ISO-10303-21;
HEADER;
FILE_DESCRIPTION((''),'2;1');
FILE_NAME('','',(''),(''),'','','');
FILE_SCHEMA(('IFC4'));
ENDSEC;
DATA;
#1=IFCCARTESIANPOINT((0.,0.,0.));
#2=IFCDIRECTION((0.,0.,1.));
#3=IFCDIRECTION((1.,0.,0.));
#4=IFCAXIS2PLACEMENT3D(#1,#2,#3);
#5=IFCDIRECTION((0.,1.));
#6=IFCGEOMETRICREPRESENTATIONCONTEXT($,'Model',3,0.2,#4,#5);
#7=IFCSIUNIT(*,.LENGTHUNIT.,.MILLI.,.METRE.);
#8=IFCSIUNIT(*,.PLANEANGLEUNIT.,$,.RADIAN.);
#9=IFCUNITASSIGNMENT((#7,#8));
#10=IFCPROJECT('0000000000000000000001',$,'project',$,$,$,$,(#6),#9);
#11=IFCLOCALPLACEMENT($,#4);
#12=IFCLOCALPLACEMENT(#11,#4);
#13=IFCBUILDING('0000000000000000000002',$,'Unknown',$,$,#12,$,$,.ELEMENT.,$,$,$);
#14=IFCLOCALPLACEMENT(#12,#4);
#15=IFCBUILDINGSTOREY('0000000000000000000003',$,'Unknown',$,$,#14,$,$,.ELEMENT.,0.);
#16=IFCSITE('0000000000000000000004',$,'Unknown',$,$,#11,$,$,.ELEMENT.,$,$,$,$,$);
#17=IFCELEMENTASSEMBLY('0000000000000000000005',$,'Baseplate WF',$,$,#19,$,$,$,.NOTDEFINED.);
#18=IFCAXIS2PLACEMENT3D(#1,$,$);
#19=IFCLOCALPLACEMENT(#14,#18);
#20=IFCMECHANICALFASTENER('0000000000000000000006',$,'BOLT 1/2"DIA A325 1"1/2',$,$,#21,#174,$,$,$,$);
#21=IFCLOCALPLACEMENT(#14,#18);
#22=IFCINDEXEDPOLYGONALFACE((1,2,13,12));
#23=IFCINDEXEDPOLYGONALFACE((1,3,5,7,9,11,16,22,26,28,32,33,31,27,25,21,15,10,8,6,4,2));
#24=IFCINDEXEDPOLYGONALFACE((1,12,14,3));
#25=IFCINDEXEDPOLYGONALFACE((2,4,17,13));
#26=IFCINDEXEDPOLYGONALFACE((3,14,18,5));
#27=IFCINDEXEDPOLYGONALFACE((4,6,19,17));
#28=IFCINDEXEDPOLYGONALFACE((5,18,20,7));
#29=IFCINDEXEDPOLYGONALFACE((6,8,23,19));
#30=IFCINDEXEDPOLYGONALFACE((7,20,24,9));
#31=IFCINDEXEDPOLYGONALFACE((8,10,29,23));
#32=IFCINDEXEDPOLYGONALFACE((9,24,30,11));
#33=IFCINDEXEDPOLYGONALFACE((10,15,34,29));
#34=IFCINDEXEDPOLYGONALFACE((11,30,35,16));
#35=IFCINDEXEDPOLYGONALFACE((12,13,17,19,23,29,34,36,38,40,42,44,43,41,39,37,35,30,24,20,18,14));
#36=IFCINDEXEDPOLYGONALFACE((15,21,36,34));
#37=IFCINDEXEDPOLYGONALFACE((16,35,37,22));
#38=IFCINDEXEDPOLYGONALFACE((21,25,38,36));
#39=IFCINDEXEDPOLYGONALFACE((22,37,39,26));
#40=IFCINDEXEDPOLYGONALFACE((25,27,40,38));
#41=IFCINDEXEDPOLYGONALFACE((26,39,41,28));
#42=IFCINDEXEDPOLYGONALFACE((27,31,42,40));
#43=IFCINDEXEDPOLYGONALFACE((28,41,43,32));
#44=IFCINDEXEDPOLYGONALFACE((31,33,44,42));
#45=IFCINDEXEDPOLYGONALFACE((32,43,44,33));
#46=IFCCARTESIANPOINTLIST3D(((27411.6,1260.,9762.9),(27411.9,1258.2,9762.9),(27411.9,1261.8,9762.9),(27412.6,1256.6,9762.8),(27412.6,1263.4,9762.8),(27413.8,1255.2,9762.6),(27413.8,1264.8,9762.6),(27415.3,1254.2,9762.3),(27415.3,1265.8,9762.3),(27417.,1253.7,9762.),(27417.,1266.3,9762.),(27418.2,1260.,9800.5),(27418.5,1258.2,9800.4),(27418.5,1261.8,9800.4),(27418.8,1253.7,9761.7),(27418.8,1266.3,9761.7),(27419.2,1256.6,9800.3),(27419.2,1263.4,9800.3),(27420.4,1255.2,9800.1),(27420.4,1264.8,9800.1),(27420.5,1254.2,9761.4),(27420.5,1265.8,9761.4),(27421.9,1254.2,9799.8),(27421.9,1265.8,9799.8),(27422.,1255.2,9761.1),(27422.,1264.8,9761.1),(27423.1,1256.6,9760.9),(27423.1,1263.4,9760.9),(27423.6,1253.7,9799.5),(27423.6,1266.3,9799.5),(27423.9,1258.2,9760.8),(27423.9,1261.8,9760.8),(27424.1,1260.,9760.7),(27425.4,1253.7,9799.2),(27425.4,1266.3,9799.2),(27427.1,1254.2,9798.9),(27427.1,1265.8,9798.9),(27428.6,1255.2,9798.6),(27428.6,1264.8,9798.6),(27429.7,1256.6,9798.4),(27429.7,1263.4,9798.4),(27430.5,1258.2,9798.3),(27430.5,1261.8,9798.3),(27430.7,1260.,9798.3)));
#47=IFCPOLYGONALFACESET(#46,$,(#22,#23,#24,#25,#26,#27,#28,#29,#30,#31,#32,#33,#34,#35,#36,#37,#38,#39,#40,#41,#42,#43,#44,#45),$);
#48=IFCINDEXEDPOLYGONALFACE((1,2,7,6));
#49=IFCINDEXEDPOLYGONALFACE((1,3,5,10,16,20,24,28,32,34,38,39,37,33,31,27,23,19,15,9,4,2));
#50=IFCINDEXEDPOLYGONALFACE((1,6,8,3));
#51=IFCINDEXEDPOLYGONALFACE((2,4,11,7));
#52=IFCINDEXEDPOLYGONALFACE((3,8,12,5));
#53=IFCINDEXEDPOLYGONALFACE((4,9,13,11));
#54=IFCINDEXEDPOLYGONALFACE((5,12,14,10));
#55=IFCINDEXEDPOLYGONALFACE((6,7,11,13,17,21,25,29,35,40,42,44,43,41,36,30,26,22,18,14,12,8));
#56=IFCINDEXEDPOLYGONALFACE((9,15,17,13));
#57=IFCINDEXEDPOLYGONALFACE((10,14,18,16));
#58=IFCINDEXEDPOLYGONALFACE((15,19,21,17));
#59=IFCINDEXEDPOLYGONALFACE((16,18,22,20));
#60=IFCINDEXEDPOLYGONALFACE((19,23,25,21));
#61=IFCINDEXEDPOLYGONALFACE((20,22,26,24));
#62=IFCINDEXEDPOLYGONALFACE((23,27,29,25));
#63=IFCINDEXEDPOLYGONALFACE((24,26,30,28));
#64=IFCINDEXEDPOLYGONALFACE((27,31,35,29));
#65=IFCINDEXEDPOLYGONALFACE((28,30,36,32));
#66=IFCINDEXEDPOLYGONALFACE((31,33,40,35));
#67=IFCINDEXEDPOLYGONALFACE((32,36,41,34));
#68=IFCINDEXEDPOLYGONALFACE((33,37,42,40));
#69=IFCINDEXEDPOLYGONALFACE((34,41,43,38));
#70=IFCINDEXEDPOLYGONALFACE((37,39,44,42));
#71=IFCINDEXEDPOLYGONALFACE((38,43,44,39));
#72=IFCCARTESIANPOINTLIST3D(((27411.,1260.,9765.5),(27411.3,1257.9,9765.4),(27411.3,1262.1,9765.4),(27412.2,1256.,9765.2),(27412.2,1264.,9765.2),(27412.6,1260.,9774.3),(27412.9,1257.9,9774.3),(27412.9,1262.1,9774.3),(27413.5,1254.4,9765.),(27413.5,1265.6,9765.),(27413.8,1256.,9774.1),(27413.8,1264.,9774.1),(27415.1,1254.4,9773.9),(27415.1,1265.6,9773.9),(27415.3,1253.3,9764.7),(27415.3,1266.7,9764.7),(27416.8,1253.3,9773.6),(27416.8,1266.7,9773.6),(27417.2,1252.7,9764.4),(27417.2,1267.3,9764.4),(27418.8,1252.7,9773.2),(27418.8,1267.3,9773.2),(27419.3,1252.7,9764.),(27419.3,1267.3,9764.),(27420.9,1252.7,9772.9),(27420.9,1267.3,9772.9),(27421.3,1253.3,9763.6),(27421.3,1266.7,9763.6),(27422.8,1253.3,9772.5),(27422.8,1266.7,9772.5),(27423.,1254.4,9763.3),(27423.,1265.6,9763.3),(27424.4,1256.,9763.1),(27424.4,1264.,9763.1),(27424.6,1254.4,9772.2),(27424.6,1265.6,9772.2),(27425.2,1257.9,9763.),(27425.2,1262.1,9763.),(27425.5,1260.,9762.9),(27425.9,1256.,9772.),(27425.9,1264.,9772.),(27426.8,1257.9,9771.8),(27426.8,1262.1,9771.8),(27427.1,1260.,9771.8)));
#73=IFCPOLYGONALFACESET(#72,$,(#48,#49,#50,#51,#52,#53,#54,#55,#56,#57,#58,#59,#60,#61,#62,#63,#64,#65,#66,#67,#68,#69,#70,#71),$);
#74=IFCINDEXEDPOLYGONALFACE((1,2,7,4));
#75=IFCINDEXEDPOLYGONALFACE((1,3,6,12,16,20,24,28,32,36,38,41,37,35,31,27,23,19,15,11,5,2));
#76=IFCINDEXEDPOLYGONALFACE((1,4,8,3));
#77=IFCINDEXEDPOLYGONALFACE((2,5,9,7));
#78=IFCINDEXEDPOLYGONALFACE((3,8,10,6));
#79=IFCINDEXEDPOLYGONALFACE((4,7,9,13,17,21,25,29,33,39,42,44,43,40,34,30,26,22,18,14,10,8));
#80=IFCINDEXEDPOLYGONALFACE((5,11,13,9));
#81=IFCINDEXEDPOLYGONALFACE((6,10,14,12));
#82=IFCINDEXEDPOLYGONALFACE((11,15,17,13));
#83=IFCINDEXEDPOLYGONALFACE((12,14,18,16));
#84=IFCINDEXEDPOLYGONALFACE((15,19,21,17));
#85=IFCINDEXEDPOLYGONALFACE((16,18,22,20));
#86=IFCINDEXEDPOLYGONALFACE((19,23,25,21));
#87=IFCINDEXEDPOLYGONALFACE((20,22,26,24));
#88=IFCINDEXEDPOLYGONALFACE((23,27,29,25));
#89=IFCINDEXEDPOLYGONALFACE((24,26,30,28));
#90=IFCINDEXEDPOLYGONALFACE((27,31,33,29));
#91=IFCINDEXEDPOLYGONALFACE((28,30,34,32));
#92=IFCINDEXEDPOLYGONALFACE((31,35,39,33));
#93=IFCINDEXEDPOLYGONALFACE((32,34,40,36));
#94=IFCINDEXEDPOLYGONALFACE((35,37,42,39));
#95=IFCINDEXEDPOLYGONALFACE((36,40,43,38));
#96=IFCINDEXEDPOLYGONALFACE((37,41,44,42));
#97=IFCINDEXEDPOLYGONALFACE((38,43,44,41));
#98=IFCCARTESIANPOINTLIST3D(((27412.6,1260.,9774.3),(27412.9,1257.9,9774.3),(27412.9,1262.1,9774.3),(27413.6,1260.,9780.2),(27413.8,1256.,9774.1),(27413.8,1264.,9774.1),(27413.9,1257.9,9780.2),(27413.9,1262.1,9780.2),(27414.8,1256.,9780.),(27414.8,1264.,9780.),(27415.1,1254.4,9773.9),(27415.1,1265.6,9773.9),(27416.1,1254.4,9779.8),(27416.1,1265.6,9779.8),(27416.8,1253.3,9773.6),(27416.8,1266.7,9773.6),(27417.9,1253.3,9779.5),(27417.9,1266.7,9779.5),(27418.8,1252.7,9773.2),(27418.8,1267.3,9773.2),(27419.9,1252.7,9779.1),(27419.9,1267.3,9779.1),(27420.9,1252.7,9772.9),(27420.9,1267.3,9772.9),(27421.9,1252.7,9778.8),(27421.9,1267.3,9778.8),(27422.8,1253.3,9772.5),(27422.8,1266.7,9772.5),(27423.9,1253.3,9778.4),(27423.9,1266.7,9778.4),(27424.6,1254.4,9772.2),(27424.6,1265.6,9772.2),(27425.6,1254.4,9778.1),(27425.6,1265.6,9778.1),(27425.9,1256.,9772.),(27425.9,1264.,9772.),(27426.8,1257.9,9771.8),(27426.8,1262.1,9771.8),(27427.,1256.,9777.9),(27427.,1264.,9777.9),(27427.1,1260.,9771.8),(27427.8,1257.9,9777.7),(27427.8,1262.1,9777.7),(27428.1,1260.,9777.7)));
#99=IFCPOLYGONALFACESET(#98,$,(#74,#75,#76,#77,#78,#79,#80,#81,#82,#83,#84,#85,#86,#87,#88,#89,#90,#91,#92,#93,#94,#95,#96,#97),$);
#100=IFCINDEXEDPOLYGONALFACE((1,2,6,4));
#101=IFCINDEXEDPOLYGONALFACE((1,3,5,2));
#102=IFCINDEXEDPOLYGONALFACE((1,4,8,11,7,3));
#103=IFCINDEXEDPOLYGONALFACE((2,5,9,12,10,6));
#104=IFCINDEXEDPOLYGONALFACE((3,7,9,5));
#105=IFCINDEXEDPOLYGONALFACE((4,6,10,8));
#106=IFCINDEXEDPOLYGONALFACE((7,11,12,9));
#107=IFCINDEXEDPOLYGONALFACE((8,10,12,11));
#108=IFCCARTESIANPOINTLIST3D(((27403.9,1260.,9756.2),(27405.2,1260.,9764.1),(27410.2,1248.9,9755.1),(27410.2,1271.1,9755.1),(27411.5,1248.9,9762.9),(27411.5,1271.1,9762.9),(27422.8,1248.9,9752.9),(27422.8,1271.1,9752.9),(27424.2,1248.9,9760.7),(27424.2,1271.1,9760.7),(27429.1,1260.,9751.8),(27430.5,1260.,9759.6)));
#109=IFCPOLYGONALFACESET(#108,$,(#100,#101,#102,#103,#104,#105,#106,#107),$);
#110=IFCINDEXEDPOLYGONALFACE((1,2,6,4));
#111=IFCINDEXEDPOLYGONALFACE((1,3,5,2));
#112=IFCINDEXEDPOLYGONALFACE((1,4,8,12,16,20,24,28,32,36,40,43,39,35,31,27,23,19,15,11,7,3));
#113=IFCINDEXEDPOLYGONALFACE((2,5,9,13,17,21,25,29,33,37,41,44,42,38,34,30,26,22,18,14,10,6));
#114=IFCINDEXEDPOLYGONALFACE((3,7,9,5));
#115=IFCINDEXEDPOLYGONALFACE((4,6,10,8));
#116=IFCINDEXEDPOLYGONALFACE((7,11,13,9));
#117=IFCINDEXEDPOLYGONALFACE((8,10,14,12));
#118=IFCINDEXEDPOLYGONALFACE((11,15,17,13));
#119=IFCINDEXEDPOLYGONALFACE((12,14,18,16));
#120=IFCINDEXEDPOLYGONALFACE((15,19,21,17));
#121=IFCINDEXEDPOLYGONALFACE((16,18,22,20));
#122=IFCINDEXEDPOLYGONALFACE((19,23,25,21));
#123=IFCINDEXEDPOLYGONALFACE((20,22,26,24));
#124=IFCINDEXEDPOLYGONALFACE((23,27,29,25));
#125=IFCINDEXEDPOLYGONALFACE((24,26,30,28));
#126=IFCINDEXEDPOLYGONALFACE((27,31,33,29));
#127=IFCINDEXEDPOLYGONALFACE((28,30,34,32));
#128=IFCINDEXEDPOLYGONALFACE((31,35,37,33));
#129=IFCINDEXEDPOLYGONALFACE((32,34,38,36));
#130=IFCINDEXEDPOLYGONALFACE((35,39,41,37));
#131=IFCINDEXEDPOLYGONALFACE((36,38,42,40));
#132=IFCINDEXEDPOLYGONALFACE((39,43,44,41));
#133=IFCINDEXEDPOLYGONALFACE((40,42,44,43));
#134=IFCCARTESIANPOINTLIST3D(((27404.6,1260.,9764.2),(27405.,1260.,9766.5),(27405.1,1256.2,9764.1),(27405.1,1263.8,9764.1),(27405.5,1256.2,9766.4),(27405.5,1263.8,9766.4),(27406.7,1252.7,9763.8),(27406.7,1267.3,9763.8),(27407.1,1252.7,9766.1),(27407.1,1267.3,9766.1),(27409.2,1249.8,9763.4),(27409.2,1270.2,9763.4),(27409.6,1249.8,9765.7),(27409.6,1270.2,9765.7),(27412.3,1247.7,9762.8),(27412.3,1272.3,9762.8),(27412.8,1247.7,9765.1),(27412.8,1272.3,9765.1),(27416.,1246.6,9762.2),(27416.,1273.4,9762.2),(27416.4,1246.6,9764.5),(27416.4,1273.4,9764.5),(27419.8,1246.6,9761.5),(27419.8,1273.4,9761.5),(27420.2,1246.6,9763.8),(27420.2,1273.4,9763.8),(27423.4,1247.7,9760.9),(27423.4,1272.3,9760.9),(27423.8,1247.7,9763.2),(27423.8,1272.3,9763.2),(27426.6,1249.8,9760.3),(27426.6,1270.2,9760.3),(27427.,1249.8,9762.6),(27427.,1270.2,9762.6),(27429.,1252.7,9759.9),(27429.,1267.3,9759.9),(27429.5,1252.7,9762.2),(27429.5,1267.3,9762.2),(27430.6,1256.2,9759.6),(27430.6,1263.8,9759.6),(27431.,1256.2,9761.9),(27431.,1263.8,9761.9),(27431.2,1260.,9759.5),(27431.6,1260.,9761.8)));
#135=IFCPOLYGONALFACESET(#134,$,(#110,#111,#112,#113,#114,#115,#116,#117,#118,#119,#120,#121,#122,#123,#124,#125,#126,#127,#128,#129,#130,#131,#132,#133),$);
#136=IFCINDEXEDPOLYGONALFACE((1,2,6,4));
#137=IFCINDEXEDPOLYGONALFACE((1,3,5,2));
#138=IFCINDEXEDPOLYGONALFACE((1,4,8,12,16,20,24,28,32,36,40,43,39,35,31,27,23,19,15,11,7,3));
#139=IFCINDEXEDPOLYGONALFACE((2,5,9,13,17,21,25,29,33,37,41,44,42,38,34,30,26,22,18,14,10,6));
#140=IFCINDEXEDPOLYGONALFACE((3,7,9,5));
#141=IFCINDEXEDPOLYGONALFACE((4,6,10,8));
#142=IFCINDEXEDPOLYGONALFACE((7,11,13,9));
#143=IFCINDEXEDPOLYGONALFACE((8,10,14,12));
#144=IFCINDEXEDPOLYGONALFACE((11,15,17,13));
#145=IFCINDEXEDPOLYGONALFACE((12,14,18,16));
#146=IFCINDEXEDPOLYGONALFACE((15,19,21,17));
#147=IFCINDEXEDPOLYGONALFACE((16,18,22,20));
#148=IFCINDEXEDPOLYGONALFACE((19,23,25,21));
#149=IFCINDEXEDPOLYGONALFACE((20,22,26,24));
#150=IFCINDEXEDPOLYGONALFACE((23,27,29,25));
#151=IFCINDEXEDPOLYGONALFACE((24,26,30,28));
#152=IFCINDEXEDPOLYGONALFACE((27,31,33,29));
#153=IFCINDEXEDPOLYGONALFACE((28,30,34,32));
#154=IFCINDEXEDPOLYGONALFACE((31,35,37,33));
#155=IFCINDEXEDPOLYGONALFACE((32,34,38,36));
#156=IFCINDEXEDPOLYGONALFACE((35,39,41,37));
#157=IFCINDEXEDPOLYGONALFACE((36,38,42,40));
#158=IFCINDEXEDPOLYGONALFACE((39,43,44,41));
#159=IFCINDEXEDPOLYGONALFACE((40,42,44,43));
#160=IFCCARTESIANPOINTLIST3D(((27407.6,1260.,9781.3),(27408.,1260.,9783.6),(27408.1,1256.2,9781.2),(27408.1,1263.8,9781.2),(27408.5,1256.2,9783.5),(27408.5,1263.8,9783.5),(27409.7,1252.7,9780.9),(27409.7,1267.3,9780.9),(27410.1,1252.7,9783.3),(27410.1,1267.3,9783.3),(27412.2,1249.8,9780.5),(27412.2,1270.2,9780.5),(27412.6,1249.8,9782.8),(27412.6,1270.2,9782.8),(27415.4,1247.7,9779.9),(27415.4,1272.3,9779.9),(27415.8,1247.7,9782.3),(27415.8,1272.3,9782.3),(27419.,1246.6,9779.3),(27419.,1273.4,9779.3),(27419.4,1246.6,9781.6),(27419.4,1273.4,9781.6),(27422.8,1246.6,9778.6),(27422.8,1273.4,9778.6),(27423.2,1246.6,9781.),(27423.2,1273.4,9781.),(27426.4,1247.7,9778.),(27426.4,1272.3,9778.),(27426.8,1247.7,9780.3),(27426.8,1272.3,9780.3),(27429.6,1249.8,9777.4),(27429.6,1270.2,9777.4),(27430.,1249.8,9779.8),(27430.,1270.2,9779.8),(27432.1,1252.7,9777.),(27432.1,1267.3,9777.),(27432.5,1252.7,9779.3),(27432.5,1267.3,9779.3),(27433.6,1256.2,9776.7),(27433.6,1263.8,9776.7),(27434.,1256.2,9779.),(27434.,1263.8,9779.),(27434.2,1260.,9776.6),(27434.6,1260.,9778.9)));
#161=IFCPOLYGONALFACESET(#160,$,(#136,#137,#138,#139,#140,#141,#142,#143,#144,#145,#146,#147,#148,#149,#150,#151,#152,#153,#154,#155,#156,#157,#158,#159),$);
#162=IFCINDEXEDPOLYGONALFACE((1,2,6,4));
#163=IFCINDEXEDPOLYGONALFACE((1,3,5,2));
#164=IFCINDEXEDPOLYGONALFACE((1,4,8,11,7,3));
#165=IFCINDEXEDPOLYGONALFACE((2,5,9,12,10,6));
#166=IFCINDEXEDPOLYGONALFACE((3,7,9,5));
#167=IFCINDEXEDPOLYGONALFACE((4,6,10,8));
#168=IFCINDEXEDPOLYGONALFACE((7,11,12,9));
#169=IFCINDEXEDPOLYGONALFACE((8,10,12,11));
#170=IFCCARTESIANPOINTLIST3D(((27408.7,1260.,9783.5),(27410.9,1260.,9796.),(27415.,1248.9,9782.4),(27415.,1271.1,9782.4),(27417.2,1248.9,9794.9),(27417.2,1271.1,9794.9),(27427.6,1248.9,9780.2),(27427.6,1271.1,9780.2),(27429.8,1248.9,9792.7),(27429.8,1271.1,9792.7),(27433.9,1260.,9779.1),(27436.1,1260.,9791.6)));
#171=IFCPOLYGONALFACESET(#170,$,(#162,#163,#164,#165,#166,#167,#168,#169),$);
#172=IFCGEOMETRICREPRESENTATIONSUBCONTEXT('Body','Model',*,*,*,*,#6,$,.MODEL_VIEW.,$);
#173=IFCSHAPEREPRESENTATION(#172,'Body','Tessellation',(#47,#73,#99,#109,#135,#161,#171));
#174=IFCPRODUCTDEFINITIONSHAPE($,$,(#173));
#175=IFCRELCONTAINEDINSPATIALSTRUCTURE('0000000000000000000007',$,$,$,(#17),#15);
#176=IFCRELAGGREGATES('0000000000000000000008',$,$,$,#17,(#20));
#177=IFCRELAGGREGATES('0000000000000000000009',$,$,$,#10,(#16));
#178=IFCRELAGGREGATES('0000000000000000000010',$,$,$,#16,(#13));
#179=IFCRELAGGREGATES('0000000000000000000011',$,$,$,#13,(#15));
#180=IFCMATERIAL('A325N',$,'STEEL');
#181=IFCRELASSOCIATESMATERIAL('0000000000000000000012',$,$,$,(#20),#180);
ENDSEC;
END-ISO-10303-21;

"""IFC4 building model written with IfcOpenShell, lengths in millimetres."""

from ifc_helpers import new_model, si_unit, direction, frame, origin_with_axes, place, context, subcontext, project, spatial, line, arc, indexed_curve, outline, extrude, source, transform, mapped, material, element, aggregate, save


model = new_model("IFC4")

# Units and contexts
model_context = context("Model", 3, precision=0.2, world=origin_with_axes(), true_north=direction((0.0, 1.0)))
body_context = subcontext(model_context, "Body", "Model", "MODEL_VIEW")
ifc_project = project(units=[si_unit("LENGTHUNIT", "METRE", prefix="MILLI"), si_unit("PLANEANGLEUNIT", "RADIAN")], contexts=[model_context])

# Site, building, storey
site_placement = place(None, origin_with_axes())
site = spatial("IfcSite", under=ifc_project, at=site_placement, Name="Unknown", CompositionType="ELEMENT")
building_placement = place(site_placement, origin_with_axes())
building = spatial("IfcBuilding", under=site, at=building_placement, Name="Unknown", CompositionType="ELEMENT")
storey_placement = place(building_placement, origin_with_axes())
storey = spatial("IfcBuildingStorey", under=building, at=storey_placement, Name="Unknown", CompositionType="ELEMENT", Elevation=0.0)

# Element assembly
assembly_1_placement = place(storey_placement, frame((27449.9, 1290.0, 9770.8), z_axis=(-0.173648, 0.0, -0.984808), x_axis=(0.0, -1.0, 0.0)))
assembly_1 = element("IfcElementAssembly", 1, at=assembly_1_placement, inside=storey, Name="Baseplate WF", PredefinedType="NOTDEFINED")

# Mechanical fastener
ifc_material_1 = material(Name="A325N", Category="STEEL")
shared_shape = source(origin_with_axes(), body_context, "Body", "SweptSolid", [
    extrude(outline(indexed_curve([(6.3, 0.0), (0.0, 6.3), (-6.3, 0.0), (0.0, -6.3)], segments=[arc(1, 2, 3), arc(3, 4, 1)])), frame((0.0, 0.0, 17.4), z_axis=(0.0, 0.0, -1.0), x_axis=(0.0, 1.0, 0.0)), (0.0, 0.0, 1.0), 38.1),
    extrude(outline(indexed_curve([(7.3, 0.0), (0.0, 7.3), (-7.3, 0.0), (0.0, -7.3)], segments=[arc(1, 2, 3), arc(3, 4, 1)])), frame((0.0, 0.0, 15.0), z_axis=(0.0, 0.0, -1.0), x_axis=(0.0, 1.0, 0.0)), (0.0, 0.0, 1.0), 9.0),
    extrude(outline(indexed_curve([(7.3, 0.0), (0.0, 7.3), (-7.3, 0.0), (0.0, -7.3)], segments=[arc(1, 2, 3), arc(3, 4, 1)])), frame((0.0, 0.0, 6.0), z_axis=(0.0, 0.0, -1.0), x_axis=(0.0, 1.0, 0.0)), (0.0, 0.0, 1.0), 6.0),
    extrude(outline(indexed_curve([(12.8, 0.0), (6.4, 11.1), (-6.4, 11.1), (-12.8, 0.0), (-6.4, -11.1), (6.4, -11.1)], segments=[line(1, 2, 3, 4, 5, 6, 1)])), frame((0.0, 0.0, 25.3), z_axis=(0.0, 0.0, -1.0), x_axis=(0.0, 1.0, 0.0)), (0.0, 0.0, 1.0), 7.9),
    extrude(outline(indexed_curve([(13.5, 0.0), (0.0, 13.5), (-13.5, 0.0), (0.0, -13.5)], segments=[arc(1, 2, 3), arc(3, 4, 1)])), frame((0.0, 0.0, 17.4), z_axis=(0.0, 0.0, -1.0), x_axis=(0.0, 1.0, 0.0)), (0.0, 0.0, 1.0), 2.4),
    extrude(outline(indexed_curve([(13.5, 0.0), (0.0, 13.5), (-13.5, 0.0), (0.0, -13.5)], segments=[arc(1, 2, 3), arc(3, 4, 1)])), frame((0.0, 0.0, 0.0), z_axis=(0.0, 0.0, -1.0), x_axis=(0.0, 1.0, 0.0)), (0.0, 0.0, 1.0), 2.4),
    extrude(outline(indexed_curve([(12.8, 0.0), (6.4, 11.1), (-6.4, 11.1), (-12.8, 0.0), (-6.4, -11.1), (6.4, -11.1)], segments=[line(1, 2, 3, 4, 5, 6, 1)])), frame((0.0, 0.0, -2.4), z_axis=(0.0, 0.0, -1.0), x_axis=(0.0, 1.0, 0.0)), (0.0, 0.0, 1.0), 12.7),
])
mechanical_fastener_1_placement = place(assembly_1_placement, frame((30.0, 30.0, -3.0), z_axis=(0.0, 0.0, 1.0), x_axis=(-1.0, 0.0, 0.0)))
mechanical_fastener_1 = element("IfcMechanicalFastener", 2, at=mechanical_fastener_1_placement, material=ifc_material_1, Name="BOLT 1/2\"DIA A325 1\"1/2", context=body_context, shape_type="MappedRepresentation", body=[
    mapped(shared_shape, transform((0.0, 0.0, 0.0))),
])
aggregate(assembly_1, [mechanical_fastener_1])

save(model, "model.ifc")
